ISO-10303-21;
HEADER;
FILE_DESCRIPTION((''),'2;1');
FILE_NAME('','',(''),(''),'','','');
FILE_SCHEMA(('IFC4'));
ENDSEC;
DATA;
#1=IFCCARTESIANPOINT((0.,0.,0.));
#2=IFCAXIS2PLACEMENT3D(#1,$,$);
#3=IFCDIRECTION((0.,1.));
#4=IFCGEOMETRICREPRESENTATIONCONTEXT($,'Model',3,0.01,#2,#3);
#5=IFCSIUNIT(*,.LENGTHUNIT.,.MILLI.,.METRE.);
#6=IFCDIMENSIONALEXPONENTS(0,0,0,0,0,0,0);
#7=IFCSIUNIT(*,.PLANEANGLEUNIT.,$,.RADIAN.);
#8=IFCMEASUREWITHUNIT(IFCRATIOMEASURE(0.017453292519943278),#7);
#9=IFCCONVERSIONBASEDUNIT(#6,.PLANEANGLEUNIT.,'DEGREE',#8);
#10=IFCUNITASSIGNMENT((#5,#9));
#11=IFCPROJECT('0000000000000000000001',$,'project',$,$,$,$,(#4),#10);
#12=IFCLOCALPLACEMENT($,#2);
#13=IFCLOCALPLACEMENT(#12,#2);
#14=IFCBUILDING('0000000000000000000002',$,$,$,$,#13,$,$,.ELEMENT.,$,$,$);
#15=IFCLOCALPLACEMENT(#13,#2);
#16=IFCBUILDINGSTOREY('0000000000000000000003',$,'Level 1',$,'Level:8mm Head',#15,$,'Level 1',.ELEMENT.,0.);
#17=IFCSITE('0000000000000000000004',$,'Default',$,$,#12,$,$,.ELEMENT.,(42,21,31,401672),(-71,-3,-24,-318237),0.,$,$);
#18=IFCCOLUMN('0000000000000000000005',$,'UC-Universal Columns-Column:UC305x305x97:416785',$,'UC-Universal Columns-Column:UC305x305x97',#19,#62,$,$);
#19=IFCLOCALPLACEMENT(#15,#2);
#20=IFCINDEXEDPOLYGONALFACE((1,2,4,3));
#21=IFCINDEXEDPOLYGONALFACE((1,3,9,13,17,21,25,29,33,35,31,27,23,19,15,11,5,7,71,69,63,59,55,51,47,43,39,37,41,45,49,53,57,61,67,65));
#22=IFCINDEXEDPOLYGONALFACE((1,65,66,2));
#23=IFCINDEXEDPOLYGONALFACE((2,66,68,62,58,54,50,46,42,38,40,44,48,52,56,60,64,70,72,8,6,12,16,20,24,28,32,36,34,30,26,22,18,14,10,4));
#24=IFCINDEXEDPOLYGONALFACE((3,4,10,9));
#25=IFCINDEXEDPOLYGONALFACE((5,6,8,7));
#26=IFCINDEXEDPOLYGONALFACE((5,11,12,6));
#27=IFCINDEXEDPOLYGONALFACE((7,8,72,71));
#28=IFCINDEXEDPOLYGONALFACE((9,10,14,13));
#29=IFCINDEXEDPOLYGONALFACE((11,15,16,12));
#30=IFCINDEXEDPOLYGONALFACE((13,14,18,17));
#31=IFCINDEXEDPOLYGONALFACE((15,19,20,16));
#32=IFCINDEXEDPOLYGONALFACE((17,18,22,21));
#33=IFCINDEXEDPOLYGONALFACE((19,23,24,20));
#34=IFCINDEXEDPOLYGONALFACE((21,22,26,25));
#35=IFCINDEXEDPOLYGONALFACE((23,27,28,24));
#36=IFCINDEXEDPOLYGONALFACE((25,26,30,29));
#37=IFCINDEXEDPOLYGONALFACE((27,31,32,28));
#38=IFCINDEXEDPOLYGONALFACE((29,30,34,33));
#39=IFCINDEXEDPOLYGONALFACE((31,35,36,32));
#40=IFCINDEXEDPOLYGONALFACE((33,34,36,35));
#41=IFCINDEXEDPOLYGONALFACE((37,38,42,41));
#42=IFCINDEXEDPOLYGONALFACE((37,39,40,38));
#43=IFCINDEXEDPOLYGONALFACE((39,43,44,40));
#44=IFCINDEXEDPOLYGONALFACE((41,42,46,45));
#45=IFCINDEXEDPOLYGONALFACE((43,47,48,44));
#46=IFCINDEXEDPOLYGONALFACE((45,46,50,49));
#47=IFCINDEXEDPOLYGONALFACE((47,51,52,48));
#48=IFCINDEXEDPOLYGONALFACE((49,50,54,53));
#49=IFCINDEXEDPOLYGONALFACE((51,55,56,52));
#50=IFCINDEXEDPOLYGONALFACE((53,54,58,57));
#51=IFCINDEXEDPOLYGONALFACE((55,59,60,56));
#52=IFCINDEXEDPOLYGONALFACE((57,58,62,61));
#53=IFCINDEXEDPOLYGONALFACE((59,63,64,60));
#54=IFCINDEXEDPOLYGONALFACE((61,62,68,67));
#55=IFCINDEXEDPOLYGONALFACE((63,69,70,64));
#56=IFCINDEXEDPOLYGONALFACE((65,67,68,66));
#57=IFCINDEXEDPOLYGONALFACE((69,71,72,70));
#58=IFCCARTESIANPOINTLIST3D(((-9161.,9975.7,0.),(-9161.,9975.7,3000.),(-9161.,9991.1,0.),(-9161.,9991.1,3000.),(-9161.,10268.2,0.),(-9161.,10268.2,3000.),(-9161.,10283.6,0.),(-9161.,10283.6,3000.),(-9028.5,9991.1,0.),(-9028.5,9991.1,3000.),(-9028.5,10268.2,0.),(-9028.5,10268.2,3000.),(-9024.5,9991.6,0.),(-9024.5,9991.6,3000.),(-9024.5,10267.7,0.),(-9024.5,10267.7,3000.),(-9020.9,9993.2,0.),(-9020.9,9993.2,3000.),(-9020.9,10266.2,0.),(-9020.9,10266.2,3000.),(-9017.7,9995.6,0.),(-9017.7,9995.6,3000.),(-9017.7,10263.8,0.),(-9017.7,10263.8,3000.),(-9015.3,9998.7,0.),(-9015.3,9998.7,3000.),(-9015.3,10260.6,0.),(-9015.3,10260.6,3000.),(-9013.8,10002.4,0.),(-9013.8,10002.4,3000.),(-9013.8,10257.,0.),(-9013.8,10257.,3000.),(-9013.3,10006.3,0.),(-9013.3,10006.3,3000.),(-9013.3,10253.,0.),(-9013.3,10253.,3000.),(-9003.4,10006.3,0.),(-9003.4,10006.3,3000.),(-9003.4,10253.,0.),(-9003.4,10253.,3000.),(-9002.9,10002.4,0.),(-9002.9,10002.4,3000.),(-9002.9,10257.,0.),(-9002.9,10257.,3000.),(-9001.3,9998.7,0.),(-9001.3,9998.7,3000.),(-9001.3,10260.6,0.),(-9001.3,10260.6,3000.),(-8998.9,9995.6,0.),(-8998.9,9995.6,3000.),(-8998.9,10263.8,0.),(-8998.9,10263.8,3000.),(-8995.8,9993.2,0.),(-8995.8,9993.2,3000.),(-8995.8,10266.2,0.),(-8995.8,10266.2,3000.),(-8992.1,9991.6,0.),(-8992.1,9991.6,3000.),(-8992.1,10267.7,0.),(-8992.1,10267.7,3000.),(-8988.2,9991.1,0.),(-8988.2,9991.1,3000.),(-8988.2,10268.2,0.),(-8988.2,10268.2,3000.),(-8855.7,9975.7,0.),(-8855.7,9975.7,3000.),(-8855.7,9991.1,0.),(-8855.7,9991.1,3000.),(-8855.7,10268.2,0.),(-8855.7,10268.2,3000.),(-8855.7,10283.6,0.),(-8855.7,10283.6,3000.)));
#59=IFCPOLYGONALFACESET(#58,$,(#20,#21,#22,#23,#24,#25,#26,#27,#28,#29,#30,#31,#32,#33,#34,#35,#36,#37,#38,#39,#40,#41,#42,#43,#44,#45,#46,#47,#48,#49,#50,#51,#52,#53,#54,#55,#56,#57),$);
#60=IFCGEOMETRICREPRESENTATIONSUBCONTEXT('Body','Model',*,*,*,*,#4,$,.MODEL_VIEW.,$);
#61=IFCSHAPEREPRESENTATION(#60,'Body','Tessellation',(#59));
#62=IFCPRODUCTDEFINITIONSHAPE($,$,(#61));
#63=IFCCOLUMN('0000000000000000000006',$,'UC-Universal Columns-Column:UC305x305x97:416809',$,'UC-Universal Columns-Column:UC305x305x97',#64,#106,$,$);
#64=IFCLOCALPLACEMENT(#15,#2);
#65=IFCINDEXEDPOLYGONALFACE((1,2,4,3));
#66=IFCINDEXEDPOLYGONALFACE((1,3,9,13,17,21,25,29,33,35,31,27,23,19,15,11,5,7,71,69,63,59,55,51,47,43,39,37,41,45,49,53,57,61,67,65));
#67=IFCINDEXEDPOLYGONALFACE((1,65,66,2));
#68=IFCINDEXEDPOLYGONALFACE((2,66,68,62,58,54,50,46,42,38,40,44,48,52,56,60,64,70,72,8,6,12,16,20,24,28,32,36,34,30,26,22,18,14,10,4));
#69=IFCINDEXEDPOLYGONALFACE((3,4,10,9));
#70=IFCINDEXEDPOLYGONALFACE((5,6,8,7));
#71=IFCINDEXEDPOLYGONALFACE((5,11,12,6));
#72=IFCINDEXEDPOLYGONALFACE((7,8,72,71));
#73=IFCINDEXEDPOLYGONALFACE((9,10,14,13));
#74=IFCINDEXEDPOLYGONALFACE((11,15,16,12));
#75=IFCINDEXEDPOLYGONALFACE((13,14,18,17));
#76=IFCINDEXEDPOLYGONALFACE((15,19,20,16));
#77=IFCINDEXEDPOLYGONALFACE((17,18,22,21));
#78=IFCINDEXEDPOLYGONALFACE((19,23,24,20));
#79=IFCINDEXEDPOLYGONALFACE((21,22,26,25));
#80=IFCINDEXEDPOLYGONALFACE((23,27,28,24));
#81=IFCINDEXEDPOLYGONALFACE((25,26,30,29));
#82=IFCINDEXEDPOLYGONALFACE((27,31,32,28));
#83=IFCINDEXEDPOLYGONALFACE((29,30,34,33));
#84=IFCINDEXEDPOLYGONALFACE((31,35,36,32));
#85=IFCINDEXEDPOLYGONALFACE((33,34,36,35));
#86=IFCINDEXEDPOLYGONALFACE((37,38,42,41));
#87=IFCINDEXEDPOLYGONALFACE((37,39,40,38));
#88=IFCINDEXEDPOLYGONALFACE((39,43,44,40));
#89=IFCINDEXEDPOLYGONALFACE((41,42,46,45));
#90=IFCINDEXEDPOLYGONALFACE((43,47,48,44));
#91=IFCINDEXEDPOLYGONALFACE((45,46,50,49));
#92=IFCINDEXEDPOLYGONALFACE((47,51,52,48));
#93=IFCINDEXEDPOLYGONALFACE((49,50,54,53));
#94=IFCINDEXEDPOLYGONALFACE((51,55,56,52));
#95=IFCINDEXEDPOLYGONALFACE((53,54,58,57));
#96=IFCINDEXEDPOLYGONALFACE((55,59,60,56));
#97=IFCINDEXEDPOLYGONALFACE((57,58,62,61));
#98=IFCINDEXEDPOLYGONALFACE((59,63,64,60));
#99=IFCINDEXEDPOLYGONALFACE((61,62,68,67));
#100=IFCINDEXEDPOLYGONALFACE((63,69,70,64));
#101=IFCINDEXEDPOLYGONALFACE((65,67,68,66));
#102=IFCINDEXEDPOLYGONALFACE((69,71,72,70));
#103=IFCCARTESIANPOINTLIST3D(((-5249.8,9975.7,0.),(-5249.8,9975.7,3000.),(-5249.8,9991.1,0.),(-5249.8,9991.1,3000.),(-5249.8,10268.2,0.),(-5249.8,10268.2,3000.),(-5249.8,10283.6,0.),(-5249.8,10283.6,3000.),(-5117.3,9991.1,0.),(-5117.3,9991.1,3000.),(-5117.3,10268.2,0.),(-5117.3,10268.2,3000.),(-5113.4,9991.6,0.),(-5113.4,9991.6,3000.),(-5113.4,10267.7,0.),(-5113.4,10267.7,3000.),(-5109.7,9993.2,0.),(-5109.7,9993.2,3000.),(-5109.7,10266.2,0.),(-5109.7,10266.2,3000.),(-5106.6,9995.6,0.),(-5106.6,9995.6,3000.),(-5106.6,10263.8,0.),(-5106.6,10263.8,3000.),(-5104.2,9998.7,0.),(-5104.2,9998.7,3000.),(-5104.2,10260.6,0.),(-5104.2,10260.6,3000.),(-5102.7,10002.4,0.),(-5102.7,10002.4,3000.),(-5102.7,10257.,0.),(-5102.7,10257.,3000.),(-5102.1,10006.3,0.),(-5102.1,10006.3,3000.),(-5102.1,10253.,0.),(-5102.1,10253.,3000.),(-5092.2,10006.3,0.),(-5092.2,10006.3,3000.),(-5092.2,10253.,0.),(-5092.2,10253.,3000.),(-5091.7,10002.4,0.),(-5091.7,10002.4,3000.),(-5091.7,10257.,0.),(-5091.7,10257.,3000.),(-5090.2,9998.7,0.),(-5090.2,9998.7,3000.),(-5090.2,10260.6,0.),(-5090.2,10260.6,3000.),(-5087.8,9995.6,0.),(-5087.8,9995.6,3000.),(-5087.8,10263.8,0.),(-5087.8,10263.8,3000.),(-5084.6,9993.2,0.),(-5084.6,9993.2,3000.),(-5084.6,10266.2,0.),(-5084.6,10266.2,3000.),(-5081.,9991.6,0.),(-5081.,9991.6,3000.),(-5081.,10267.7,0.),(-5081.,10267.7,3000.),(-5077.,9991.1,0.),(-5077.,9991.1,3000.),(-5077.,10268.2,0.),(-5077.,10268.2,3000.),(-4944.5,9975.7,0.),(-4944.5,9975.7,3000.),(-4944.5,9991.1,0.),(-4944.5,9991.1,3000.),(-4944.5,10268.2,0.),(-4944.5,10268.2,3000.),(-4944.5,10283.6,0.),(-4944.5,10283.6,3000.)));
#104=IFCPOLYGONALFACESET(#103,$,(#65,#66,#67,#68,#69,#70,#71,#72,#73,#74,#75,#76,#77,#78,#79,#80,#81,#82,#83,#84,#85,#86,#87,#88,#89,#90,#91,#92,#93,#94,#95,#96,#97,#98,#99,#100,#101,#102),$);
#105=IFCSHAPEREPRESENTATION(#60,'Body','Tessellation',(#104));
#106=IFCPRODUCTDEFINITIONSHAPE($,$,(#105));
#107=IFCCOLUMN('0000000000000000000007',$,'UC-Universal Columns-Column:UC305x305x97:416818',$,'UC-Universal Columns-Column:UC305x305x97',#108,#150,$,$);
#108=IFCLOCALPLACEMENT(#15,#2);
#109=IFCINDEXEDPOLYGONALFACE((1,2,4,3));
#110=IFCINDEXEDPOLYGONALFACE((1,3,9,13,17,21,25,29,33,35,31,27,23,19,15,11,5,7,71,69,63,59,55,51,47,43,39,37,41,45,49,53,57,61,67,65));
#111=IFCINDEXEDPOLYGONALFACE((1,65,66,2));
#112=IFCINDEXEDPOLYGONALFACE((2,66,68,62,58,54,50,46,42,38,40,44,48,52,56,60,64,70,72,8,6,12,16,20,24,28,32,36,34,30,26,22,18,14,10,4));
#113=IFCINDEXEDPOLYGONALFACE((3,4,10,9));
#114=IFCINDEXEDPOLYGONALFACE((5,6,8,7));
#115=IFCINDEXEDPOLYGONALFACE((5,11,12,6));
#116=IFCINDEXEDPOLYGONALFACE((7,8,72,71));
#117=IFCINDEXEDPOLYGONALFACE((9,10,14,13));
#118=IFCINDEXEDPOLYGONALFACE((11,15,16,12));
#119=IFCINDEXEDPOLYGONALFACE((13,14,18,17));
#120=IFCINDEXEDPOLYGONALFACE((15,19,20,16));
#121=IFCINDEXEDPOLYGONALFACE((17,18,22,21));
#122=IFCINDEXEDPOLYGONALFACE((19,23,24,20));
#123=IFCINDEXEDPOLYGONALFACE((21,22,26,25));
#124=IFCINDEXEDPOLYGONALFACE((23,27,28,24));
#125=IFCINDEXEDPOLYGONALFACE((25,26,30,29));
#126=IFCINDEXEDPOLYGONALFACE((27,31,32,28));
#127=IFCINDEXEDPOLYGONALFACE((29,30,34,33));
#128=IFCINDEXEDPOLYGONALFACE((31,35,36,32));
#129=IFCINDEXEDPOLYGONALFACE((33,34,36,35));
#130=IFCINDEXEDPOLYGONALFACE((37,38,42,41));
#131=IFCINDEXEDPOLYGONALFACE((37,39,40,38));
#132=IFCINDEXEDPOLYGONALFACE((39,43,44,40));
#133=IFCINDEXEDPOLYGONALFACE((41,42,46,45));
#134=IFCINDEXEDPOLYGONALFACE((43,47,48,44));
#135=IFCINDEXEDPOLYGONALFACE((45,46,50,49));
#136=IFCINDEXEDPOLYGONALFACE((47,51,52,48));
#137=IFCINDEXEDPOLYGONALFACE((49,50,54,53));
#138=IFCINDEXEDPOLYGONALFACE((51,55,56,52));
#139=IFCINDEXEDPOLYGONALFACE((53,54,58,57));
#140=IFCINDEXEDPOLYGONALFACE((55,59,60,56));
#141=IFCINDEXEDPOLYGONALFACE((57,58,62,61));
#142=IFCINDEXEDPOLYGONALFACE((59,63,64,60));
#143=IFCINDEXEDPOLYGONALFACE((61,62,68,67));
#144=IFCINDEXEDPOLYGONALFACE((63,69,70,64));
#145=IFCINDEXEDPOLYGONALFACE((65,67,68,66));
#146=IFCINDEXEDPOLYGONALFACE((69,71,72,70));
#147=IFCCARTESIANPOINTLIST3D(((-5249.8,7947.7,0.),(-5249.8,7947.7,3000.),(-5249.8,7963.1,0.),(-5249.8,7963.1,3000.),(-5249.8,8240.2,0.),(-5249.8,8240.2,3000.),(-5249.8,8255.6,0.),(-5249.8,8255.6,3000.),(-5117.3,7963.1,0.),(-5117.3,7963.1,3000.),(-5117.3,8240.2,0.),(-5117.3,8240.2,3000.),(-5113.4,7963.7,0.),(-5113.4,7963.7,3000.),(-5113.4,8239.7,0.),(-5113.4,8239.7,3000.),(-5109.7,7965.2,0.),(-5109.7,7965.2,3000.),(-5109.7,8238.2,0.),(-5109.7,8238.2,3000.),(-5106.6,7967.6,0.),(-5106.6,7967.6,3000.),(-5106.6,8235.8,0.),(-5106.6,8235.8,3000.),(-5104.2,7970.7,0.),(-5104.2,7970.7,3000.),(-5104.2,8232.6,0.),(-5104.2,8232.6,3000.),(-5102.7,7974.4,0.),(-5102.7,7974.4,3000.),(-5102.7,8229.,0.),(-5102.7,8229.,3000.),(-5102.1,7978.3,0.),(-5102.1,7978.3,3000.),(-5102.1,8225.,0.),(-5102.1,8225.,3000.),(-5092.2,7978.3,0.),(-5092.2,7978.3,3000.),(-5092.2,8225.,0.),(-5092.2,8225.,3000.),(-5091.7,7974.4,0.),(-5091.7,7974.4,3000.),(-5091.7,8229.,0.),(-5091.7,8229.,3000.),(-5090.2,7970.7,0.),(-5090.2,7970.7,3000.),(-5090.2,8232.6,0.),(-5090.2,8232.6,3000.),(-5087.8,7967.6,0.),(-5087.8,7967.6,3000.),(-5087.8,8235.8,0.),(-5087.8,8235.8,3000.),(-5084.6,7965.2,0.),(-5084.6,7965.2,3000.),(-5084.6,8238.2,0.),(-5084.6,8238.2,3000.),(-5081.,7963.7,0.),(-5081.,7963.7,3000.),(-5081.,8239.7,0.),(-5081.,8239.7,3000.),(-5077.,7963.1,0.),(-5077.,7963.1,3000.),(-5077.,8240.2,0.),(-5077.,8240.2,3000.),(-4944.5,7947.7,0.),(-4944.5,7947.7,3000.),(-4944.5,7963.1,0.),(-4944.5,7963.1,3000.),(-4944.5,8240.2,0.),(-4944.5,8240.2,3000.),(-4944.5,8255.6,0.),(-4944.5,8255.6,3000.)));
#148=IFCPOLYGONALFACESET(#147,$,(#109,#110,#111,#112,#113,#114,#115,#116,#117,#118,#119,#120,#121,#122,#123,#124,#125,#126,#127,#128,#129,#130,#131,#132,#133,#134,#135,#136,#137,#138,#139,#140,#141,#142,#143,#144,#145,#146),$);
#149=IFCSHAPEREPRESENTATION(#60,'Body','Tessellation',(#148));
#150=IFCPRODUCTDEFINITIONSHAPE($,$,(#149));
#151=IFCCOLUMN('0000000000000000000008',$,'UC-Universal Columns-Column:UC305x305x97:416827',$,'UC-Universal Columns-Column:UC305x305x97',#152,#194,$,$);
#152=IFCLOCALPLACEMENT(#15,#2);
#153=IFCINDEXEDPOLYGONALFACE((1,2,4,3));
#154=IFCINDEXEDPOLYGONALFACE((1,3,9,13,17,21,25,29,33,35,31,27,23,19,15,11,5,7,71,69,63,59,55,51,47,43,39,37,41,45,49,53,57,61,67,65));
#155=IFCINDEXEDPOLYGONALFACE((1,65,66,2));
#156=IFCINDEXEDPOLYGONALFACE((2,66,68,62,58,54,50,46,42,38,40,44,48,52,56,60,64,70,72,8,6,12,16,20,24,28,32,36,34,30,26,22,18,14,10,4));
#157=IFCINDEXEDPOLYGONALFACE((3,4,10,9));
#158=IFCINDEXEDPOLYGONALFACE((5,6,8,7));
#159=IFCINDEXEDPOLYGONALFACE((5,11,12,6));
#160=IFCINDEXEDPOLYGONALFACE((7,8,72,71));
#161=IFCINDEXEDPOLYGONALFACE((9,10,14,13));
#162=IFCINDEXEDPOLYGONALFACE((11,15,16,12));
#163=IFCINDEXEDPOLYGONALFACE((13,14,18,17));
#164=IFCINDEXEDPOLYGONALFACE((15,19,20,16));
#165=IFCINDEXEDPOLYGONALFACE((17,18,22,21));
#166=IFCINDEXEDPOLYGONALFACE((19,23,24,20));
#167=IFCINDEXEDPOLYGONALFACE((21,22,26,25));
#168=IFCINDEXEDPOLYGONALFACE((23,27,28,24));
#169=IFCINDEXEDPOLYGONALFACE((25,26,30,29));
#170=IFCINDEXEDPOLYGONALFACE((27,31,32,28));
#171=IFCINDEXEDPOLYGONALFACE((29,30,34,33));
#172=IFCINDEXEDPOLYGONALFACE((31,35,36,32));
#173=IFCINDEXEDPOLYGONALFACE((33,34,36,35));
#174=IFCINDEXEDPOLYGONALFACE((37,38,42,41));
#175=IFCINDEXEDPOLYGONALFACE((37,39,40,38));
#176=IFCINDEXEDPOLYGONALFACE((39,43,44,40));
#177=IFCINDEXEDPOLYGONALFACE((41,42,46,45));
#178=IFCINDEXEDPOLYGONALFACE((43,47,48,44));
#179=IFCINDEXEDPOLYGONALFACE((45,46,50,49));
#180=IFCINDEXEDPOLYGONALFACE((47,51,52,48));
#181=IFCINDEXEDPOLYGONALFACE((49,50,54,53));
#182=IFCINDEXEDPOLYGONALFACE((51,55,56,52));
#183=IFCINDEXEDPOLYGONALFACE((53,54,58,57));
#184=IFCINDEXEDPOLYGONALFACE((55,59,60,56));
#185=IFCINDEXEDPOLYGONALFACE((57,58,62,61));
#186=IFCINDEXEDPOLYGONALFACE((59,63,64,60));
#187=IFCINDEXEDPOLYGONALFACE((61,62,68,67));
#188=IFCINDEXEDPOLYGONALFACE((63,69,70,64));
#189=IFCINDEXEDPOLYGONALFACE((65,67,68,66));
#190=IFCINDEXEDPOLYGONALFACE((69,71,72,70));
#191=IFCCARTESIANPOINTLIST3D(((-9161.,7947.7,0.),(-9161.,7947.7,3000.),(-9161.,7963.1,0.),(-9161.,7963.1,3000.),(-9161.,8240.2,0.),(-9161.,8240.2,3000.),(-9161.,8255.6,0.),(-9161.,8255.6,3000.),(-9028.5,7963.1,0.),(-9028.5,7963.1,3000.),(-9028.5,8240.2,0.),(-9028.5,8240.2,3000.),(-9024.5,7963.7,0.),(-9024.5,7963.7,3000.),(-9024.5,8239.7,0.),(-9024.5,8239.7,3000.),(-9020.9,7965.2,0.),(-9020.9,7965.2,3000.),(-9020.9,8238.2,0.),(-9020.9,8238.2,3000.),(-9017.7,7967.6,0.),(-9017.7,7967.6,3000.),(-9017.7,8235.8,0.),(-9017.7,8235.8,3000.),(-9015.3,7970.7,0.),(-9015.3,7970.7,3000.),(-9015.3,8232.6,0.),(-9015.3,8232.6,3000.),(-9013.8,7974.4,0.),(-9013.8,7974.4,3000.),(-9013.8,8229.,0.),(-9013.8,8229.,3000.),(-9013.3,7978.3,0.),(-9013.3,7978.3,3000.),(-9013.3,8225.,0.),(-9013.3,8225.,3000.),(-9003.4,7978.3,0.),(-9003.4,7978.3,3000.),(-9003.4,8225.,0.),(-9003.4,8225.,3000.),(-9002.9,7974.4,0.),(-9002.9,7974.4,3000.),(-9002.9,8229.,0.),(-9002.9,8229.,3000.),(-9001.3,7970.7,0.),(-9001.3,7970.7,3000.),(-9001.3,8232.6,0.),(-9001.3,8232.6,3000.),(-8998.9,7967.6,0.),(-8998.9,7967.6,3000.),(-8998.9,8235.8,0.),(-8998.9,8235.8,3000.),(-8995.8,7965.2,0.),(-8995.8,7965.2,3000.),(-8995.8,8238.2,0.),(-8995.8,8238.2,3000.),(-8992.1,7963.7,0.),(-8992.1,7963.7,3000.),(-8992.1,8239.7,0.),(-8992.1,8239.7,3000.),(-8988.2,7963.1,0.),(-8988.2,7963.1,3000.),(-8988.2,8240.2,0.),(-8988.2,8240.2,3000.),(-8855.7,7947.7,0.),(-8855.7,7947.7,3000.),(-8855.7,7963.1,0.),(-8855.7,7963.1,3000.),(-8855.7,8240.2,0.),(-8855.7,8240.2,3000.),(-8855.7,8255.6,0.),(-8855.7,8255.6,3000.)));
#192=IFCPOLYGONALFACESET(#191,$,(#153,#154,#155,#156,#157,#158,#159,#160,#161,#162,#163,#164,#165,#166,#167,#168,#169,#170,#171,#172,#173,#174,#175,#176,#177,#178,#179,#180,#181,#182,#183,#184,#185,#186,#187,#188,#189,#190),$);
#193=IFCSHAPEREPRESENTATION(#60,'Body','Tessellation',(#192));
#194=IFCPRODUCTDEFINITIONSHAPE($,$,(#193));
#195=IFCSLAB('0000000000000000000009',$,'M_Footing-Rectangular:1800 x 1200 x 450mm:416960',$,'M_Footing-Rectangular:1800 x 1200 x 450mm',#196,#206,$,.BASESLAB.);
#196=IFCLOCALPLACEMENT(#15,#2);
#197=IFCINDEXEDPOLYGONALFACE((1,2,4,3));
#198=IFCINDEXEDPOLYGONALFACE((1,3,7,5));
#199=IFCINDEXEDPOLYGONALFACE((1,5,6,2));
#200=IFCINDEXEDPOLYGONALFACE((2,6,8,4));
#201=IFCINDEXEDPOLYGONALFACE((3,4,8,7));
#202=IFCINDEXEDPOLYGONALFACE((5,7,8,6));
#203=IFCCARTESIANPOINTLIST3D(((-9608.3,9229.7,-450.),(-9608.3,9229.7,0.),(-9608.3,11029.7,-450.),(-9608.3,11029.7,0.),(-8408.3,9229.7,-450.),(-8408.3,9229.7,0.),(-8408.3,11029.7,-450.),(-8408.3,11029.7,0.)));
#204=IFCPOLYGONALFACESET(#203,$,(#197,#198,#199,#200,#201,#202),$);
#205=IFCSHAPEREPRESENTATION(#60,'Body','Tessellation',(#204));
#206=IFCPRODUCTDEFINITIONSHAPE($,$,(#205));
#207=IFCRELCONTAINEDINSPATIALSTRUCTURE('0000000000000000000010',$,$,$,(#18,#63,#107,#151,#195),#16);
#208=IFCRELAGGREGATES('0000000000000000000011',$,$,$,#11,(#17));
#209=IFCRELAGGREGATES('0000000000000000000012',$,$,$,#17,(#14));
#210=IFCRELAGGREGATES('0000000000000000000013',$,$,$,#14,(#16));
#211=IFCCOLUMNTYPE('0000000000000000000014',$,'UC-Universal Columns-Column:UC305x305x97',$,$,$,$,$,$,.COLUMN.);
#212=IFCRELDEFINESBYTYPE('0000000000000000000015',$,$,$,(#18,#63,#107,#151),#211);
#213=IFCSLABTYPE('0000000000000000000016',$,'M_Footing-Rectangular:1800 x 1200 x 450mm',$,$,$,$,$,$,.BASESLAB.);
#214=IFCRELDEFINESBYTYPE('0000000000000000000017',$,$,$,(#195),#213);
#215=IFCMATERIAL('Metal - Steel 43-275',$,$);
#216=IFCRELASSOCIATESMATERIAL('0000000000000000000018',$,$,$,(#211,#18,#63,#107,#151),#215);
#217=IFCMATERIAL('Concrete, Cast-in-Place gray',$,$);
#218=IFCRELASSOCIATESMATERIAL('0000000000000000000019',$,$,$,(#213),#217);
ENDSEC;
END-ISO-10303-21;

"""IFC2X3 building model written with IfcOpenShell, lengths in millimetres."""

from ifc_helpers import new_model, entity, si_unit, converted_unit, direction, frame, frame_2d, origin, place, context, subcontext, project, spatial, rectangle, i_section, extrude, source, transform, mapped, material, type_object, type_shapes, element, save


model = new_model("IFC2X3")

# Units and contexts
model_context = context("Model", 3, precision=0.01, world=origin(), true_north=direction((0.0, 1.0)))
body_context = subcontext(model_context, "Body", "Model", "MODEL_VIEW")
ifc_project = project(units=[si_unit("LENGTHUNIT", "METRE", prefix="MILLI"), converted_unit("PLANEANGLEUNIT", "DEGREE", entity("IfcRatioMeasure", 0.017453292519943278), si_unit("PLANEANGLEUNIT", "RADIAN"), dimensions=[0, 0, 0, 0, 0, 0, 0])], contexts=[model_context])

# Site, building, storey
site_placement = place(None, origin())
site = spatial("IfcSite", under=ifc_project, at=site_placement, Name="Default", CompositionType="ELEMENT", RefLatitude=(42, 21, 31, 401672), RefLongitude=(-71, -3, -24, -318237), RefElevation=0.0)
building_placement = place(site_placement, origin())
building = spatial("IfcBuilding", under=site, at=building_placement, CompositionType="ELEMENT")
storey_placement = place(building_placement, origin())
storey = spatial("IfcBuildingStorey", under=building, at=storey_placement, Name="Level 1", ObjectType="Level:8mm Head", LongName="Level 1", CompositionType="ELEMENT", Elevation=0.0)

# Columns
ifc_material_1 = material(Name="Metal - Steel 43-275")
column_type = type_object("IfcColumnType", Name="UC-Universal Columns-Column:UC305x305x97", PredefinedType="COLUMN", material=ifc_material_1)
shared_shape = source(origin(), body_context, "Body", "SweptSolid", [
    extrude(i_section(OverallWidth=305.3, OverallDepth=307.9, WebThickness=9.9, FlangeThickness=15.4, FilletRadius=15.2, at=frame_2d((0.0, 0.0), x_axis=(0.0, 1.0))), frame((0.0, 0.0, 0.0), z_axis=(0.0, 0.0, 1.0), x_axis=(0.0, -1.0, 0.0)), (0.0, 0.0, 1.0), 3000.0),
])
type_shapes(column_type, [shared_shape])
for number, where, name in (
    (1, (-9008.3, 10129.7, 0.0), "UC-Universal Columns-Column:UC305x305x97:416785"),
    (2, (-5097.2, 10129.7, 0.0), "UC-Universal Columns-Column:UC305x305x97:416809"),
    (3, (-5097.2, 8101.7, 0.0), "UC-Universal Columns-Column:UC305x305x97:416818"),
    (4, (-9008.3, 8101.7, 0.0), "UC-Universal Columns-Column:UC305x305x97:416827"),
):
    element("IfcColumn", number, at=place(storey_placement, frame(where)), inside=storey, type_object=column_type, material=ifc_material_1, Name=name, ObjectType="UC-Universal Columns-Column:UC305x305x97", context=body_context, shape_type="MappedRepresentation", body=[
        mapped(shared_shape, transform((0.0, 0.0, 0.0), scale=1.0)),
    ])

# Slab
ifc_material_2 = material(Name="Concrete, Cast-in-Place gray")
slab_type = type_object("IfcSlabType", Name="M_Footing-Rectangular:1800 x 1200 x 450mm", PredefinedType="BASESLAB", material=ifc_material_2)
slab_1_placement = place(storey_placement, origin())
element("IfcSlab", 5, at=slab_1_placement, inside=storey, type_object=slab_type, Name="M_Footing-Rectangular:1800 x 1200 x 450mm:416960", ObjectType="M_Footing-Rectangular:1800 x 1200 x 450mm", PredefinedType="BASESLAB", context=body_context, shape_type="SweptSolid", body=[
    extrude(rectangle(XDim=1200.0, YDim=1800.0, at=frame_2d((0.0, 0.0), x_axis=(1.0, 0.0))), frame((-9008.3, 10129.7, -450.0), z_axis=(0.0, 0.0, 1.0), x_axis=(-1.0, 0.0, 0.0)), (0.0, 0.0, 1.0), 450.0),
])

save(model, "model.ifc")
